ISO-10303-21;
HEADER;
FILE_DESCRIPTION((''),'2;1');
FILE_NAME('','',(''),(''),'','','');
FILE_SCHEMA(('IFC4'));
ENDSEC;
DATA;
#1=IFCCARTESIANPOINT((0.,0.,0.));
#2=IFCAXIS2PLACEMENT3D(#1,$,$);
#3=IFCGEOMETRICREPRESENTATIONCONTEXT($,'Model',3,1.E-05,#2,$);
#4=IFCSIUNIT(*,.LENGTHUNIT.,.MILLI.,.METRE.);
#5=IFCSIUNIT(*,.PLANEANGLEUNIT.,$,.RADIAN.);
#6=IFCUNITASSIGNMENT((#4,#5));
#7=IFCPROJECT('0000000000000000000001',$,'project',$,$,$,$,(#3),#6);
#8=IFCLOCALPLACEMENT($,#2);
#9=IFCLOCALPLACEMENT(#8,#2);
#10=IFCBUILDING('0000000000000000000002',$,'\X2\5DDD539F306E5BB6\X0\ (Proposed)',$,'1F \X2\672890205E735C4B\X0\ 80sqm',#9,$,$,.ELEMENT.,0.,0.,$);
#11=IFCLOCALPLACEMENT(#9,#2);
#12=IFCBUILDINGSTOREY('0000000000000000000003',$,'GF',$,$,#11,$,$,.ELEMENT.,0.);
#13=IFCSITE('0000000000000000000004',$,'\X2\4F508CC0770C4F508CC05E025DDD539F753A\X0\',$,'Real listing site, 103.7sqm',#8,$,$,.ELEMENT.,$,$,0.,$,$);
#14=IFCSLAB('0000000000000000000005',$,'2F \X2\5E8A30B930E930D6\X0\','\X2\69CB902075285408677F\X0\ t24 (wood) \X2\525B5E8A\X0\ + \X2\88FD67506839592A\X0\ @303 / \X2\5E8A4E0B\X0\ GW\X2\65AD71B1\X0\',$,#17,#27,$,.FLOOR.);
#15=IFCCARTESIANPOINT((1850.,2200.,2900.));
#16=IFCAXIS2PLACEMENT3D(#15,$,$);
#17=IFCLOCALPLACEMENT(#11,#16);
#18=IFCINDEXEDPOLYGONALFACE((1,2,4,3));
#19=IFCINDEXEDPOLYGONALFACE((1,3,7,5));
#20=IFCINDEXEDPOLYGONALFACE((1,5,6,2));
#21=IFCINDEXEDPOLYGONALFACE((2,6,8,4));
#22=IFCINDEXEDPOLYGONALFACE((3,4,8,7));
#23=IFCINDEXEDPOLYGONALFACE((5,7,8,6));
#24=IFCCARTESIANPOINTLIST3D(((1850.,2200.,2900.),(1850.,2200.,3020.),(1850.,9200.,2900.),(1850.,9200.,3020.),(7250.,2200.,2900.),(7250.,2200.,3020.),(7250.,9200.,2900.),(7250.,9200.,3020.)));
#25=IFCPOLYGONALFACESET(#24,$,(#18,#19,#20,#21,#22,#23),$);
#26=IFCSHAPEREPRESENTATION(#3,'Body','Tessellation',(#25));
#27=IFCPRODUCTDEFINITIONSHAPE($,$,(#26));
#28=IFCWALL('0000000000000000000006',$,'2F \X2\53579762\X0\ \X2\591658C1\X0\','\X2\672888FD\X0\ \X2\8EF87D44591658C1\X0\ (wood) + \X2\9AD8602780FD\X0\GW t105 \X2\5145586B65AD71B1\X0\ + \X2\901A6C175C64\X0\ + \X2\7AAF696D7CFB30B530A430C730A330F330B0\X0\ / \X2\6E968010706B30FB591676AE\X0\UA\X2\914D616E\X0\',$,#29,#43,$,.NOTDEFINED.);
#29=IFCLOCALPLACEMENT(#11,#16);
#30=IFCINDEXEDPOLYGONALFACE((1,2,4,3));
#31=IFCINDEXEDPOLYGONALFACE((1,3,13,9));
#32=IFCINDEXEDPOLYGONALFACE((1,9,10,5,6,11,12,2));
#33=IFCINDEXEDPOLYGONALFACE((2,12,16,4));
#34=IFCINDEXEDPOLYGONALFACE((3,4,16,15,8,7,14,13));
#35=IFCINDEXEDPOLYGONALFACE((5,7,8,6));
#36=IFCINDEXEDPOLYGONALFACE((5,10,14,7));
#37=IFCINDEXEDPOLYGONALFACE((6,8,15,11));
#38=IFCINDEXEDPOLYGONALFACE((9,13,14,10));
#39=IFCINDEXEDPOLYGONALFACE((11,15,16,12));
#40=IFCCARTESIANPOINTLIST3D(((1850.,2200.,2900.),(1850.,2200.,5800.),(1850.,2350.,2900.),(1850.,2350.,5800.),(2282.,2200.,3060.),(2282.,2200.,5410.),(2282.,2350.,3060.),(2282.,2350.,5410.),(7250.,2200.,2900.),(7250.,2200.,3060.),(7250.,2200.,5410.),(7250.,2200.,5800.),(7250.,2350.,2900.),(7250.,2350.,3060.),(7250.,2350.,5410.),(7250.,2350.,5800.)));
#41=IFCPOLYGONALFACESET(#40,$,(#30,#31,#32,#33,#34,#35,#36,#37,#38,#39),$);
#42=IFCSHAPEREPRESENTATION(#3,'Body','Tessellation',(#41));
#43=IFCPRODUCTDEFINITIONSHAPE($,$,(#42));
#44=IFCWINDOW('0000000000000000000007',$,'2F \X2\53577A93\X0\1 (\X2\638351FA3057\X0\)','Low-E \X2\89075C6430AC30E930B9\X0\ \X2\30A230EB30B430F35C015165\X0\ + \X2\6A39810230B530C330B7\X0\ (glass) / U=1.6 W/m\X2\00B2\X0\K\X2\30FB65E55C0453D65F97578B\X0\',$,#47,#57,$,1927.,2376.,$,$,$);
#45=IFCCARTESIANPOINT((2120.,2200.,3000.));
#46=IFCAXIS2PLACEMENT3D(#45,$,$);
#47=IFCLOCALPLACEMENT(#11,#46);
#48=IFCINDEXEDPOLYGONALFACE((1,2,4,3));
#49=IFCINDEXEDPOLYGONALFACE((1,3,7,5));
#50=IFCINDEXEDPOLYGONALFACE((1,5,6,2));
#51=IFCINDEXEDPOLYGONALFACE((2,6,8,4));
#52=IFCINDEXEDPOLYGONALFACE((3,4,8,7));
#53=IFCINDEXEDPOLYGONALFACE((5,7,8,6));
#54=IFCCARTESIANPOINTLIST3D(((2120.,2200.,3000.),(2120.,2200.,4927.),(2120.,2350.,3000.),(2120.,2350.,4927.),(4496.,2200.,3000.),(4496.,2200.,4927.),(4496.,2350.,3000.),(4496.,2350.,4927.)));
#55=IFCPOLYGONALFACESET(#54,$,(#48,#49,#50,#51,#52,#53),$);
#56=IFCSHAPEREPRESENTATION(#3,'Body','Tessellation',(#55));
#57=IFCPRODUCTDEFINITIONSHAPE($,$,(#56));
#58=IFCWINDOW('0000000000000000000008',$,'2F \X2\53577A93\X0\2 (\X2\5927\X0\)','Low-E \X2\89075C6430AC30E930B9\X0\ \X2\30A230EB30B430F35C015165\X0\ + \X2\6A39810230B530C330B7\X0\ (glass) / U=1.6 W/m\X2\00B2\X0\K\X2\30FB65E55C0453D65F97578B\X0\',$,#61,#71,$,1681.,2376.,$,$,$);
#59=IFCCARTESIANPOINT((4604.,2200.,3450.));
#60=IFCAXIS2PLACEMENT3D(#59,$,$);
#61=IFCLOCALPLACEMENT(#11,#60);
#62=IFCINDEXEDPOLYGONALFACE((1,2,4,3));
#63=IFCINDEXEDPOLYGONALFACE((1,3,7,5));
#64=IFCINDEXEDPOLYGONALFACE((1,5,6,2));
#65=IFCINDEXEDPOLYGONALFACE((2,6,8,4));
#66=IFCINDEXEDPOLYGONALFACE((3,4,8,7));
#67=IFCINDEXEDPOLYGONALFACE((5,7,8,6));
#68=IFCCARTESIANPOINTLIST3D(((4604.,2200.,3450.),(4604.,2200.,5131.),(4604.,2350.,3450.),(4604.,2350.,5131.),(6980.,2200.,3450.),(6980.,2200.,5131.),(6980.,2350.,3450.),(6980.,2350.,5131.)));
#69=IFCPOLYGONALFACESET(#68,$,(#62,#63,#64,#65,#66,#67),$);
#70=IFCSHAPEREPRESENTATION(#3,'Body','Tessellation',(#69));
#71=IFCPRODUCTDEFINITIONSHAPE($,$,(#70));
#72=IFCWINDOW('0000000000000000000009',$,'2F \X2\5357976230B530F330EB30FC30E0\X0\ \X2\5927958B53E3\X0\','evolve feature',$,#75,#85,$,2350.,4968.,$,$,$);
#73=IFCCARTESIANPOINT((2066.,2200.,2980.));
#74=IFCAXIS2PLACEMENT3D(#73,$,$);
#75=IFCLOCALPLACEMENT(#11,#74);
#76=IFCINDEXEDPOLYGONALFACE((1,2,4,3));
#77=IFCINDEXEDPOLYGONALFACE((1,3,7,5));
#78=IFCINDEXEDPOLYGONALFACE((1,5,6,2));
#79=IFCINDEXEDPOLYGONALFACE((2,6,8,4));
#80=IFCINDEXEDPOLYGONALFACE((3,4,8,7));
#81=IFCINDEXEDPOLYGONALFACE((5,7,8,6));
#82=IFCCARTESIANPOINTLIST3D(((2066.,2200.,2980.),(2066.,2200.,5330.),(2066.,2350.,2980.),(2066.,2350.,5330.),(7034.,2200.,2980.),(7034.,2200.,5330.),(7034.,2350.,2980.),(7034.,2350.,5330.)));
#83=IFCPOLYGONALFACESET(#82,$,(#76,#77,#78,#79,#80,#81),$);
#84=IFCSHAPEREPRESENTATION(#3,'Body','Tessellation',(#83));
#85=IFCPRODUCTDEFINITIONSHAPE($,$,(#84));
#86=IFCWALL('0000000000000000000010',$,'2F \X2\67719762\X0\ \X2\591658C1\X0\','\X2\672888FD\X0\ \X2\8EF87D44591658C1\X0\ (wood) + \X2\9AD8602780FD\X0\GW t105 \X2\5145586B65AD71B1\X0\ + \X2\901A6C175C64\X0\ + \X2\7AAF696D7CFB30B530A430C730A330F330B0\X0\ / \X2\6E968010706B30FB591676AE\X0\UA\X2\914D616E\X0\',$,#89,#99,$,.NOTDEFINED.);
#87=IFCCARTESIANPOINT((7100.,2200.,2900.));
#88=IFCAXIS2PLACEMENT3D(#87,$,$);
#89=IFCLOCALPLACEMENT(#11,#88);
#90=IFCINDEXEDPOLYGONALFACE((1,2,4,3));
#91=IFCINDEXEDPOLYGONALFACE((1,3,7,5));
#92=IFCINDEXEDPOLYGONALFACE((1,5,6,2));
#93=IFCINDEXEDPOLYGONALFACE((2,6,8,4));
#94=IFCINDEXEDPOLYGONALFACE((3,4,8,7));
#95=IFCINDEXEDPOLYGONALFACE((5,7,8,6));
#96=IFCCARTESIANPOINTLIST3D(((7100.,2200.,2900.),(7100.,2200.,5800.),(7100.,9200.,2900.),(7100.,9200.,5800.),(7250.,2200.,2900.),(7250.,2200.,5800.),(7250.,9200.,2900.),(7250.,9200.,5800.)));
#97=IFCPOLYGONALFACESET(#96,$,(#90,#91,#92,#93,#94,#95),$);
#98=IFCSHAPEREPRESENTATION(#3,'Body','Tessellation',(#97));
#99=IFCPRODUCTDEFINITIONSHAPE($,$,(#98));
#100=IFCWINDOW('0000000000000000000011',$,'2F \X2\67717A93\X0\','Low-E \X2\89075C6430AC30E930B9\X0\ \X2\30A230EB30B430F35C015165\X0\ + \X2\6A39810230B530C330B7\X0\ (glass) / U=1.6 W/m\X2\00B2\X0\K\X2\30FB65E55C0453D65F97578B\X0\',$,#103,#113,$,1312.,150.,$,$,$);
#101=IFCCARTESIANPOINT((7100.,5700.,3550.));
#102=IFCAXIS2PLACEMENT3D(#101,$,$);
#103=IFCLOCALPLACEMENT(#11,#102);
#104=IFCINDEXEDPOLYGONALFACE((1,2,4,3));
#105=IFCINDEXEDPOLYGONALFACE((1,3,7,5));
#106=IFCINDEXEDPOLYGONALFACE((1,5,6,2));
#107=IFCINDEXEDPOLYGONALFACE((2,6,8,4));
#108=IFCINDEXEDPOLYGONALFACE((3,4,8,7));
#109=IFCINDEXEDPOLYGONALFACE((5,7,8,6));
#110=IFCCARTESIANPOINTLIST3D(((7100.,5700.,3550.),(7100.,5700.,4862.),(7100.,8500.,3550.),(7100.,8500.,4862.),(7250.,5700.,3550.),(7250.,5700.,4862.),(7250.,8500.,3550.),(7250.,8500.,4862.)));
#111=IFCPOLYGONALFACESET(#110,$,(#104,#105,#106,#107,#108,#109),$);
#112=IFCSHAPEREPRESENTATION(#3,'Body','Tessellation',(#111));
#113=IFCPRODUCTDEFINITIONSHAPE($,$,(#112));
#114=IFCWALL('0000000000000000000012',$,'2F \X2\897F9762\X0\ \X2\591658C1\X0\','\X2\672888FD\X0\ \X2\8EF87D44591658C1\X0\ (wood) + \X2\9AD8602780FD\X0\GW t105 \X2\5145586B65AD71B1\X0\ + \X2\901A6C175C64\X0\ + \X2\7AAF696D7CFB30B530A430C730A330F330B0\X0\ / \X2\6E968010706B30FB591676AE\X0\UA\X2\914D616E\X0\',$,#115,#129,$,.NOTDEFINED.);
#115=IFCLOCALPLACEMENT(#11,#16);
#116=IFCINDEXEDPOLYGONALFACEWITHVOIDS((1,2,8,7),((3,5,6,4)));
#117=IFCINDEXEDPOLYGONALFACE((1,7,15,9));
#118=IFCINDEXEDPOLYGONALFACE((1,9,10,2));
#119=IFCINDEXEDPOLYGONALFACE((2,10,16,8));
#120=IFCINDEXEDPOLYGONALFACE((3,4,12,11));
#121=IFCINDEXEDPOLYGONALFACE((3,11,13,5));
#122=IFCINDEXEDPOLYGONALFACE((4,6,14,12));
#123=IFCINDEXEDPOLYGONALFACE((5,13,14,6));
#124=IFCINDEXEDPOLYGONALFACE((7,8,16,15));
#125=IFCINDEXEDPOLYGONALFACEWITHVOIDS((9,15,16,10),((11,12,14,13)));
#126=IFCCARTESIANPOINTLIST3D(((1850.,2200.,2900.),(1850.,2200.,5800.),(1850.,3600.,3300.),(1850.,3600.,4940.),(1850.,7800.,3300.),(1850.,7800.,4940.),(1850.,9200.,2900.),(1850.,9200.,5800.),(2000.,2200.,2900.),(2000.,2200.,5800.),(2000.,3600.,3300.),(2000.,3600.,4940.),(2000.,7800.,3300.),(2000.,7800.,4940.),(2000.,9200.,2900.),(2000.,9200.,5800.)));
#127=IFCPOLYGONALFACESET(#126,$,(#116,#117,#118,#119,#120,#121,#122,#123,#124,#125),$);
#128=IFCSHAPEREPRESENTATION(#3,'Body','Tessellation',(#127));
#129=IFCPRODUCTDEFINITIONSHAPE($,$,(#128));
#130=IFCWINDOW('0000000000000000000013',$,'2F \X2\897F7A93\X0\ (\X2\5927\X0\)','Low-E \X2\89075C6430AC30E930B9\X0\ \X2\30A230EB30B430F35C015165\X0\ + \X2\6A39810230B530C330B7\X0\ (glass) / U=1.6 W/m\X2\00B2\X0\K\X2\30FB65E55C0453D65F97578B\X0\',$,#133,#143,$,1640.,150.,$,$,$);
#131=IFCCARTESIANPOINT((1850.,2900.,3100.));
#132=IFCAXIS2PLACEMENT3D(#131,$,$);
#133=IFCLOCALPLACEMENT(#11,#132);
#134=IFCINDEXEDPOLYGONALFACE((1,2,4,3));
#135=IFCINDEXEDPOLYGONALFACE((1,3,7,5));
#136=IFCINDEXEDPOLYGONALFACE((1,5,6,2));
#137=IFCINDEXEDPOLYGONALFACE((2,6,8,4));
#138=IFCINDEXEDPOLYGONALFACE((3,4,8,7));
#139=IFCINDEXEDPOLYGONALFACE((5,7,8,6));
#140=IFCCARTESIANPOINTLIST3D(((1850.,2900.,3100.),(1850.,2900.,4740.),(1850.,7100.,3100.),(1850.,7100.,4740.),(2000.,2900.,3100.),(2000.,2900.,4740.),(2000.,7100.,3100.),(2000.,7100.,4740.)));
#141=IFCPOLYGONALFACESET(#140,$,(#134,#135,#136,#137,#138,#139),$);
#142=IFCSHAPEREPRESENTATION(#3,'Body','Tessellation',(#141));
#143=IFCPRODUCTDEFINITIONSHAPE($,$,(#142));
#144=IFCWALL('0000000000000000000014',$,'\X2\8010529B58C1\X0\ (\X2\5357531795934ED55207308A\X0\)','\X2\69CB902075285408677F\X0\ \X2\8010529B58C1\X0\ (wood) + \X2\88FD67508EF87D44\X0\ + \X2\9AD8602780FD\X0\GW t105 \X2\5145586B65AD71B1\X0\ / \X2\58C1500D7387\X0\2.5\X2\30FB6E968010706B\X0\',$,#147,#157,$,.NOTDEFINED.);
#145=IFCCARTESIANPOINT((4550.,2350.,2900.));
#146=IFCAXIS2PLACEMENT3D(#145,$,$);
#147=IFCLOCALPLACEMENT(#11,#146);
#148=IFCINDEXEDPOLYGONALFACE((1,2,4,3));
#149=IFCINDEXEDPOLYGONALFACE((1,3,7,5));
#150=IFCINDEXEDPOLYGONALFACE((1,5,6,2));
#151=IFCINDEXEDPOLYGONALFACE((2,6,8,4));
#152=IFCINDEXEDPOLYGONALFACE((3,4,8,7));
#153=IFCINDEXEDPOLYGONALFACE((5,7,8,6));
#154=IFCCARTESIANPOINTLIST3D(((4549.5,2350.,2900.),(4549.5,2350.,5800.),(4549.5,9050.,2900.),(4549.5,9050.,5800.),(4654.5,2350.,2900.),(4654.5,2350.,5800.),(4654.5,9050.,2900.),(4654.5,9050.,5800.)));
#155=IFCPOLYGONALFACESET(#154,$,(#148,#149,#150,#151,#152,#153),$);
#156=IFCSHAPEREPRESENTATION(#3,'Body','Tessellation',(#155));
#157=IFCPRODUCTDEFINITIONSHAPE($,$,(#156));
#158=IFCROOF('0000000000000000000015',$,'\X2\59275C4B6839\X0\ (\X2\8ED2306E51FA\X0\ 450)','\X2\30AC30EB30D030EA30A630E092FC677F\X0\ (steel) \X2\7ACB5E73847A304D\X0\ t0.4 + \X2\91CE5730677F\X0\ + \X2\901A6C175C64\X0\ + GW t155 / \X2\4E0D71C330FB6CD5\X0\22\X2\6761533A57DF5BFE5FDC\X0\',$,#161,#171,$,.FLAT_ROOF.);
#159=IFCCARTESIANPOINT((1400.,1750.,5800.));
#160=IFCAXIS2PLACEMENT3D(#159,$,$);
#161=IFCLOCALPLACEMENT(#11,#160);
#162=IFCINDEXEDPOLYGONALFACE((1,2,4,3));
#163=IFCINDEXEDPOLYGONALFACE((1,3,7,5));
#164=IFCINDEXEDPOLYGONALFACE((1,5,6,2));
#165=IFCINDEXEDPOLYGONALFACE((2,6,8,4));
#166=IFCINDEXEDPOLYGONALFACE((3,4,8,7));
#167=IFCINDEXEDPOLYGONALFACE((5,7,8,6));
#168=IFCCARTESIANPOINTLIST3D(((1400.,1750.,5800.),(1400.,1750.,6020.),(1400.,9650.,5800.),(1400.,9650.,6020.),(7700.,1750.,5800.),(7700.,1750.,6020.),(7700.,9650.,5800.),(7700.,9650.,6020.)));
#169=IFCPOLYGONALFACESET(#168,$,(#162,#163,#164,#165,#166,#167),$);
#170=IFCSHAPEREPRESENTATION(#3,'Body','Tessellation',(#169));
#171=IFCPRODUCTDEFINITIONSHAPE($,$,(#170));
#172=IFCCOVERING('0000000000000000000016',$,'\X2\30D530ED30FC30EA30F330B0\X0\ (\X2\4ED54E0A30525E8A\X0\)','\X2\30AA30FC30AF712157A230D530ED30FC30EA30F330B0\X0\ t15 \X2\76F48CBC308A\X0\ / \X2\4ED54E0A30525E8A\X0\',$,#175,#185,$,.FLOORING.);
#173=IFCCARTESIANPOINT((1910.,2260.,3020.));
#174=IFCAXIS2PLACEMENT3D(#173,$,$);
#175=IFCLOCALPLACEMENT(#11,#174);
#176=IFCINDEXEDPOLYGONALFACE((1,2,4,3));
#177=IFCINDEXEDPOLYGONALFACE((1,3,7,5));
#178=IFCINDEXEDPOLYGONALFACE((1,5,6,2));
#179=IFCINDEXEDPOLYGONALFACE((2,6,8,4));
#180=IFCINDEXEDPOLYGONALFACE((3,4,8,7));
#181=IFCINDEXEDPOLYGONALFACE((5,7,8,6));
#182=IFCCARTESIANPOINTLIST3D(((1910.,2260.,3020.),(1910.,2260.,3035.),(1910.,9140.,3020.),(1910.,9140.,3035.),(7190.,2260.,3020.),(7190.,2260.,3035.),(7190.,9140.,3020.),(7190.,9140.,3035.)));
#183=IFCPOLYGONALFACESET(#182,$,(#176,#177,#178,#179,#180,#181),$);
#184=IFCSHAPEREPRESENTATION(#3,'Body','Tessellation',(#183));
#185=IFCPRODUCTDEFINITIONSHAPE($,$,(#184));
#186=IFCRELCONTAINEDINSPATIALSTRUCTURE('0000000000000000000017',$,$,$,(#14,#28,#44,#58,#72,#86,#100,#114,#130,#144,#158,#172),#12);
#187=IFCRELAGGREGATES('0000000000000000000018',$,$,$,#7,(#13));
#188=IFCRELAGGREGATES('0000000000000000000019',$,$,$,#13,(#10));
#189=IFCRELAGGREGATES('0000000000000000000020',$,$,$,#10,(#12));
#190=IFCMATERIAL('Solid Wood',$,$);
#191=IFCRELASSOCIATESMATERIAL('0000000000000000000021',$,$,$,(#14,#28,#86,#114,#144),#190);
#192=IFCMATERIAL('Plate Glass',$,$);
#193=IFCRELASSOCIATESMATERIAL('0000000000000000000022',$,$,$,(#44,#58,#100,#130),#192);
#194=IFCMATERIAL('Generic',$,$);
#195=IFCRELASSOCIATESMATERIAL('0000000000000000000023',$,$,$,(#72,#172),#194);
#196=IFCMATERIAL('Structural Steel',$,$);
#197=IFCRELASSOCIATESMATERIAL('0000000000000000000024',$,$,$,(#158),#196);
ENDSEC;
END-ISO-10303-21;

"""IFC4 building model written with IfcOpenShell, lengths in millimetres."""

from ifc_helpers import new_model, si_unit, frame, frame_2d, origin, place, context, project, spatial, rectangle, extrude, material, element, fill, save


model = new_model("IFC4")

# Units and contexts
model_context = context("Model", 3, precision=1e-05, world=origin())
ifc_project = project(units=[si_unit("LENGTHUNIT", "METRE", prefix="MILLI"), si_unit("PLANEANGLEUNIT", "RADIAN")], contexts=[model_context])

# Site, building, storey
site_placement = place(None, origin())
site = spatial("IfcSite", under=ifc_project, at=site_placement, Name="佐賀県佐賀市川原町", ObjectType="Real listing site, 103.7sqm", CompositionType="ELEMENT", RefElevation=0.0)
building_placement = place(site_placement, origin())
building = spatial("IfcBuilding", under=site, at=building_placement, Name="川原の家 (Proposed)", ObjectType="1F 木造平屋 80sqm", CompositionType="ELEMENT", ElevationOfRefHeight=0.0, ElevationOfTerrain=0.0)
storey_placement = place(building_placement, origin())
storey = spatial("IfcBuildingStorey", under=building, at=storey_placement, Name="GF", CompositionType="ELEMENT", Elevation=0.0)

# Slab
ifc_material_1 = material(Name="Solid Wood")
slab_placement = place(storey_placement, frame((1850.0, 2200.0, 2900.0)))
element("IfcSlab", 1, at=slab_placement, inside=storey, material=ifc_material_1, Name="2F 床スラブ", Description="構造用合板 t24 (wood) 剛床 + 製材根太 @303 / 床下 GW断熱", PredefinedType="FLOOR", context=model_context, shape_type="SweptSolid", body=[
    extrude(rectangle(XDim=5400.0, YDim=7000.0, at=frame_2d((2700.0, 3500.0))), frame((1850.0, 2200.0, 2900.0)), (0.0, 0.0, 1.0), 120.0),
])

# Wall, openings, windows
wall_1_placement = place(storey_placement, frame((1850.0, 2200.0, 2900.0)))
wall_1 = element("IfcWall", 2, at=wall_1_placement, inside=storey, material=ifc_material_1, Name="2F 南面 外壁", Description="木製 軸組外壁 (wood) + 高性能GW t105 充填断熱 + 通気層 + 窯業系サイディング / 準耐火・外皮UA配慮", PredefinedType="NOTDEFINED", context=model_context, shape_type="SweptSolid", body=[
    extrude(rectangle(XDim=5400.0, YDim=150.0, at=frame_2d((2700.0, 75.0))), frame((1850.0, 2200.0, 2900.0)), (0.0, 0.0, 1.0), 2900.0),
])
opening_1_placement = place(storey_placement, frame((2120.0, 2200.0, 3000.0)))
opening_1 = element("IfcOpeningElement", 3, at=opening_1_placement, cuts=wall_1, PredefinedType="NOTDEFINED", context=model_context, shape_type="SweptSolid", body=[
    extrude(rectangle(XDim=2376.0, YDim=150.0, at=frame_2d((1188.0, 75.0))), frame((2120.0, 2200.0, 3000.0)), (0.0, 0.0, 1.0), 1927.0),
])
opening_2_placement = place(storey_placement, frame((4604.0, 2200.0, 3450.0)))
opening_2 = element("IfcOpeningElement", 4, at=opening_2_placement, cuts=wall_1, PredefinedType="NOTDEFINED", context=model_context, shape_type="SweptSolid", body=[
    extrude(rectangle(XDim=2376.0, YDim=150.0, at=frame_2d((1188.0, 75.0))), frame((4604.0, 2200.0, 3450.0)), (0.0, 0.0, 1.0), 1681.0),
])
opening_3_placement = place(storey_placement, frame((2066.0, 2200.0, 2980.0)))
opening_3 = element("IfcOpeningElement", 5, at=opening_3_placement, cuts=wall_1, PredefinedType="NOTDEFINED", context=model_context, shape_type="SweptSolid", body=[
    extrude(rectangle(XDim=4968.0, YDim=150.0, at=frame_2d((2484.0, 75.0))), frame((2066.0, 2200.0, 2980.0)), (0.0, 0.0, 1.0), 2350.0),
])
ifc_material_2 = material(Name="Plate Glass")
window_1_placement = place(storey_placement, frame((2120.0, 2200.0, 3000.0)))
window_1 = element("IfcWindow", 6, at=window_1_placement, inside=storey, material=ifc_material_2, Name="2F 南窓1 (掃出し)", Description="Low-E 複層ガラス アルゴン封入 + 樹脂サッシ (glass) / U=1.6 W/m²K・日射取得型", OverallHeight=1927.0, OverallWidth=2376.0, context=model_context, shape_type="SweptSolid", body=[
    extrude(rectangle(XDim=2376.0, YDim=150.0, at=frame_2d((1188.0, 75.0))), frame((2120.0, 2200.0, 3000.0)), (0.0, 0.0, 1.0), 1927.0),
])
fill(opening_1, window_1)
window_2_placement = place(storey_placement, frame((4604.0, 2200.0, 3450.0)))
window_2 = element("IfcWindow", 7, at=window_2_placement, inside=storey, material=ifc_material_2, Name="2F 南窓2 (大)", Description="Low-E 複層ガラス アルゴン封入 + 樹脂サッシ (glass) / U=1.6 W/m²K・日射取得型", OverallHeight=1681.0, OverallWidth=2376.0, context=model_context, shape_type="SweptSolid", body=[
    extrude(rectangle(XDim=2376.0, YDim=150.0, at=frame_2d((1188.0, 75.0))), frame((4604.0, 2200.0, 3450.0)), (0.0, 0.0, 1.0), 1681.0),
])
fill(opening_2, window_2)
ifc_material_3 = material(Name="Generic")
window_3_placement = place(storey_placement, frame((2066.0, 2200.0, 2980.0)))
window_3 = element("IfcWindow", 8, at=window_3_placement, inside=storey, material=ifc_material_3, Name="2F 南面サンルーム 大開口", Description="evolve feature", OverallHeight=2350.0, OverallWidth=4968.0, context=model_context, shape_type="SweptSolid", body=[
    extrude(rectangle(XDim=4968.0, YDim=150.0, at=frame_2d((2484.0, 75.0))), frame((2066.0, 2200.0, 2980.0)), (0.0, 0.0, 1.0), 2350.0),
])
fill(opening_3, window_3)

# Walls, openings, windows
wall_2_placement = place(storey_placement, frame((7100.0, 2200.0, 2900.0)))
wall_2 = element("IfcWall", 9, at=wall_2_placement, inside=storey, material=ifc_material_1, Name="2F 東面 外壁", Description="木製 軸組外壁 (wood) + 高性能GW t105 充填断熱 + 通気層 + 窯業系サイディング / 準耐火・外皮UA配慮", PredefinedType="NOTDEFINED", context=model_context, shape_type="SweptSolid", body=[
    extrude(rectangle(XDim=150.0, YDim=7000.0, at=frame_2d((75.0, 3500.0))), frame((7100.0, 2200.0, 2900.0)), (0.0, 0.0, 1.0), 2900.0),
])
opening_4_placement = place(storey_placement, frame((7100.0, 5700.0, 3550.0)))
opening_4 = element("IfcOpeningElement", 10, at=opening_4_placement, cuts=wall_2, PredefinedType="NOTDEFINED", context=model_context, shape_type="SweptSolid", body=[
    extrude(rectangle(XDim=150.0, YDim=2800.0, at=frame_2d((75.0, 1400.0))), frame((7100.0, 5700.0, 3550.0)), (0.0, 0.0, 1.0), 1312.0),
])
window_4_placement = place(storey_placement, frame((7100.0, 5700.0, 3550.0)))
window_4 = element("IfcWindow", 11, at=window_4_placement, inside=storey, material=ifc_material_2, Name="2F 東窓", Description="Low-E 複層ガラス アルゴン封入 + 樹脂サッシ (glass) / U=1.6 W/m²K・日射取得型", OverallHeight=1312.0, OverallWidth=150.0, context=model_context, shape_type="SweptSolid", body=[
    extrude(rectangle(XDim=150.0, YDim=2800.0, at=frame_2d((75.0, 1400.0))), frame((7100.0, 5700.0, 3550.0)), (0.0, 0.0, 1.0), 1312.0),
])
fill(opening_4, window_4)
wall_3_placement = place(storey_placement, frame((1850.0, 2200.0, 2900.0)))
wall_3 = element("IfcWall", 12, at=wall_3_placement, inside=storey, material=ifc_material_1, Name="2F 西面 外壁", Description="木製 軸組外壁 (wood) + 高性能GW t105 充填断熱 + 通気層 + 窯業系サイディング / 準耐火・外皮UA配慮", PredefinedType="NOTDEFINED", context=model_context, shape_type="SweptSolid", body=[
    extrude(rectangle(XDim=150.0, YDim=7000.0, at=frame_2d((75.0, 3500.0))), frame((1850.0, 2200.0, 2900.0)), (0.0, 0.0, 1.0), 2900.0),
])
opening_5_placement = place(storey_placement, frame((1850.0, 2900.0, 3100.0)))
opening_5 = element("IfcOpeningElement", 13, at=opening_5_placement, cuts=wall_3, PredefinedType="NOTDEFINED", context=model_context, shape_type="SweptSolid", body=[
    extrude(rectangle(XDim=150.0, YDim=4200.0, at=frame_2d((75.0, 2100.0))), frame((1850.0, 2900.0, 3100.0)), (0.0, 0.0, 1.0), 1640.0),
])
window_5_placement = place(storey_placement, frame((1850.0, 2900.0, 3100.0)))
window_5 = element("IfcWindow", 14, at=window_5_placement, inside=storey, material=ifc_material_2, Name="2F 西窓 (大)", Description="Low-E 複層ガラス アルゴン封入 + 樹脂サッシ (glass) / U=1.6 W/m²K・日射取得型", OverallHeight=1640.0, OverallWidth=150.0, context=model_context, shape_type="SweptSolid", body=[
    extrude(rectangle(XDim=150.0, YDim=4200.0, at=frame_2d((75.0, 2100.0))), frame((1850.0, 2900.0, 3100.0)), (0.0, 0.0, 1.0), 1640.0),
])
fill(opening_5, window_5)

# Wall
wall_4_placement = place(storey_placement, frame((4550.0, 2350.0, 2900.0)))
element("IfcWall", 15, at=wall_4_placement, inside=storey, material=ifc_material_1, Name="耐力壁 (南北間仕切り)", Description="構造用合板 耐力壁 (wood) + 製材軸組 + 高性能GW t105 充填断熱 / 壁倍率2.5・準耐火", PredefinedType="NOTDEFINED", context=model_context, shape_type="SweptSolid", body=[
    extrude(rectangle(XDim=105.0, YDim=6700.0, at=frame_2d((52.0, 3350.0))), frame((4550.0, 2350.0, 2900.0)), (0.0, 0.0, 1.0), 2900.0),
])

# Roof
ifc_material_4 = material(Name="Structural Steel")
roof_placement = place(storey_placement, frame((1400.0, 1750.0, 5800.0)))
element("IfcRoof", 16, at=roof_placement, inside=storey, material=ifc_material_4, Name="大屋根 (軒の出 450)", Description="ガルバリウム鋼板 (steel) 立平葺き t0.4 + 野地板 + 通気層 + GW t155 / 不燃・法22条区域対応", PredefinedType="FLAT_ROOF", context=model_context, shape_type="SweptSolid", body=[
    extrude(rectangle(XDim=6300.0, YDim=7900.0, at=frame_2d((3150.0, 3950.0))), frame((1400.0, 1750.0, 5800.0)), (0.0, 0.0, 1.0), 220.0),
])

# Covering
covering_placement = place(storey_placement, frame((1910.0, 2260.0, 3020.0)))
element("IfcCovering", 17, at=covering_placement, inside=storey, material=ifc_material_3, Name="フローリング (仕上げ床)", Description="オーク無垢フローリング t15 直貼り / 仕上げ床", PredefinedType="FLOORING", context=model_context, shape_type="SweptSolid", body=[
    extrude(rectangle(XDim=5280.0, YDim=6880.0, at=frame_2d((2640.0, 3440.0))), frame((1910.0, 2260.0, 3020.0)), (0.0, 0.0, 1.0), 15.0),
])

save(model, "model.ifc")
